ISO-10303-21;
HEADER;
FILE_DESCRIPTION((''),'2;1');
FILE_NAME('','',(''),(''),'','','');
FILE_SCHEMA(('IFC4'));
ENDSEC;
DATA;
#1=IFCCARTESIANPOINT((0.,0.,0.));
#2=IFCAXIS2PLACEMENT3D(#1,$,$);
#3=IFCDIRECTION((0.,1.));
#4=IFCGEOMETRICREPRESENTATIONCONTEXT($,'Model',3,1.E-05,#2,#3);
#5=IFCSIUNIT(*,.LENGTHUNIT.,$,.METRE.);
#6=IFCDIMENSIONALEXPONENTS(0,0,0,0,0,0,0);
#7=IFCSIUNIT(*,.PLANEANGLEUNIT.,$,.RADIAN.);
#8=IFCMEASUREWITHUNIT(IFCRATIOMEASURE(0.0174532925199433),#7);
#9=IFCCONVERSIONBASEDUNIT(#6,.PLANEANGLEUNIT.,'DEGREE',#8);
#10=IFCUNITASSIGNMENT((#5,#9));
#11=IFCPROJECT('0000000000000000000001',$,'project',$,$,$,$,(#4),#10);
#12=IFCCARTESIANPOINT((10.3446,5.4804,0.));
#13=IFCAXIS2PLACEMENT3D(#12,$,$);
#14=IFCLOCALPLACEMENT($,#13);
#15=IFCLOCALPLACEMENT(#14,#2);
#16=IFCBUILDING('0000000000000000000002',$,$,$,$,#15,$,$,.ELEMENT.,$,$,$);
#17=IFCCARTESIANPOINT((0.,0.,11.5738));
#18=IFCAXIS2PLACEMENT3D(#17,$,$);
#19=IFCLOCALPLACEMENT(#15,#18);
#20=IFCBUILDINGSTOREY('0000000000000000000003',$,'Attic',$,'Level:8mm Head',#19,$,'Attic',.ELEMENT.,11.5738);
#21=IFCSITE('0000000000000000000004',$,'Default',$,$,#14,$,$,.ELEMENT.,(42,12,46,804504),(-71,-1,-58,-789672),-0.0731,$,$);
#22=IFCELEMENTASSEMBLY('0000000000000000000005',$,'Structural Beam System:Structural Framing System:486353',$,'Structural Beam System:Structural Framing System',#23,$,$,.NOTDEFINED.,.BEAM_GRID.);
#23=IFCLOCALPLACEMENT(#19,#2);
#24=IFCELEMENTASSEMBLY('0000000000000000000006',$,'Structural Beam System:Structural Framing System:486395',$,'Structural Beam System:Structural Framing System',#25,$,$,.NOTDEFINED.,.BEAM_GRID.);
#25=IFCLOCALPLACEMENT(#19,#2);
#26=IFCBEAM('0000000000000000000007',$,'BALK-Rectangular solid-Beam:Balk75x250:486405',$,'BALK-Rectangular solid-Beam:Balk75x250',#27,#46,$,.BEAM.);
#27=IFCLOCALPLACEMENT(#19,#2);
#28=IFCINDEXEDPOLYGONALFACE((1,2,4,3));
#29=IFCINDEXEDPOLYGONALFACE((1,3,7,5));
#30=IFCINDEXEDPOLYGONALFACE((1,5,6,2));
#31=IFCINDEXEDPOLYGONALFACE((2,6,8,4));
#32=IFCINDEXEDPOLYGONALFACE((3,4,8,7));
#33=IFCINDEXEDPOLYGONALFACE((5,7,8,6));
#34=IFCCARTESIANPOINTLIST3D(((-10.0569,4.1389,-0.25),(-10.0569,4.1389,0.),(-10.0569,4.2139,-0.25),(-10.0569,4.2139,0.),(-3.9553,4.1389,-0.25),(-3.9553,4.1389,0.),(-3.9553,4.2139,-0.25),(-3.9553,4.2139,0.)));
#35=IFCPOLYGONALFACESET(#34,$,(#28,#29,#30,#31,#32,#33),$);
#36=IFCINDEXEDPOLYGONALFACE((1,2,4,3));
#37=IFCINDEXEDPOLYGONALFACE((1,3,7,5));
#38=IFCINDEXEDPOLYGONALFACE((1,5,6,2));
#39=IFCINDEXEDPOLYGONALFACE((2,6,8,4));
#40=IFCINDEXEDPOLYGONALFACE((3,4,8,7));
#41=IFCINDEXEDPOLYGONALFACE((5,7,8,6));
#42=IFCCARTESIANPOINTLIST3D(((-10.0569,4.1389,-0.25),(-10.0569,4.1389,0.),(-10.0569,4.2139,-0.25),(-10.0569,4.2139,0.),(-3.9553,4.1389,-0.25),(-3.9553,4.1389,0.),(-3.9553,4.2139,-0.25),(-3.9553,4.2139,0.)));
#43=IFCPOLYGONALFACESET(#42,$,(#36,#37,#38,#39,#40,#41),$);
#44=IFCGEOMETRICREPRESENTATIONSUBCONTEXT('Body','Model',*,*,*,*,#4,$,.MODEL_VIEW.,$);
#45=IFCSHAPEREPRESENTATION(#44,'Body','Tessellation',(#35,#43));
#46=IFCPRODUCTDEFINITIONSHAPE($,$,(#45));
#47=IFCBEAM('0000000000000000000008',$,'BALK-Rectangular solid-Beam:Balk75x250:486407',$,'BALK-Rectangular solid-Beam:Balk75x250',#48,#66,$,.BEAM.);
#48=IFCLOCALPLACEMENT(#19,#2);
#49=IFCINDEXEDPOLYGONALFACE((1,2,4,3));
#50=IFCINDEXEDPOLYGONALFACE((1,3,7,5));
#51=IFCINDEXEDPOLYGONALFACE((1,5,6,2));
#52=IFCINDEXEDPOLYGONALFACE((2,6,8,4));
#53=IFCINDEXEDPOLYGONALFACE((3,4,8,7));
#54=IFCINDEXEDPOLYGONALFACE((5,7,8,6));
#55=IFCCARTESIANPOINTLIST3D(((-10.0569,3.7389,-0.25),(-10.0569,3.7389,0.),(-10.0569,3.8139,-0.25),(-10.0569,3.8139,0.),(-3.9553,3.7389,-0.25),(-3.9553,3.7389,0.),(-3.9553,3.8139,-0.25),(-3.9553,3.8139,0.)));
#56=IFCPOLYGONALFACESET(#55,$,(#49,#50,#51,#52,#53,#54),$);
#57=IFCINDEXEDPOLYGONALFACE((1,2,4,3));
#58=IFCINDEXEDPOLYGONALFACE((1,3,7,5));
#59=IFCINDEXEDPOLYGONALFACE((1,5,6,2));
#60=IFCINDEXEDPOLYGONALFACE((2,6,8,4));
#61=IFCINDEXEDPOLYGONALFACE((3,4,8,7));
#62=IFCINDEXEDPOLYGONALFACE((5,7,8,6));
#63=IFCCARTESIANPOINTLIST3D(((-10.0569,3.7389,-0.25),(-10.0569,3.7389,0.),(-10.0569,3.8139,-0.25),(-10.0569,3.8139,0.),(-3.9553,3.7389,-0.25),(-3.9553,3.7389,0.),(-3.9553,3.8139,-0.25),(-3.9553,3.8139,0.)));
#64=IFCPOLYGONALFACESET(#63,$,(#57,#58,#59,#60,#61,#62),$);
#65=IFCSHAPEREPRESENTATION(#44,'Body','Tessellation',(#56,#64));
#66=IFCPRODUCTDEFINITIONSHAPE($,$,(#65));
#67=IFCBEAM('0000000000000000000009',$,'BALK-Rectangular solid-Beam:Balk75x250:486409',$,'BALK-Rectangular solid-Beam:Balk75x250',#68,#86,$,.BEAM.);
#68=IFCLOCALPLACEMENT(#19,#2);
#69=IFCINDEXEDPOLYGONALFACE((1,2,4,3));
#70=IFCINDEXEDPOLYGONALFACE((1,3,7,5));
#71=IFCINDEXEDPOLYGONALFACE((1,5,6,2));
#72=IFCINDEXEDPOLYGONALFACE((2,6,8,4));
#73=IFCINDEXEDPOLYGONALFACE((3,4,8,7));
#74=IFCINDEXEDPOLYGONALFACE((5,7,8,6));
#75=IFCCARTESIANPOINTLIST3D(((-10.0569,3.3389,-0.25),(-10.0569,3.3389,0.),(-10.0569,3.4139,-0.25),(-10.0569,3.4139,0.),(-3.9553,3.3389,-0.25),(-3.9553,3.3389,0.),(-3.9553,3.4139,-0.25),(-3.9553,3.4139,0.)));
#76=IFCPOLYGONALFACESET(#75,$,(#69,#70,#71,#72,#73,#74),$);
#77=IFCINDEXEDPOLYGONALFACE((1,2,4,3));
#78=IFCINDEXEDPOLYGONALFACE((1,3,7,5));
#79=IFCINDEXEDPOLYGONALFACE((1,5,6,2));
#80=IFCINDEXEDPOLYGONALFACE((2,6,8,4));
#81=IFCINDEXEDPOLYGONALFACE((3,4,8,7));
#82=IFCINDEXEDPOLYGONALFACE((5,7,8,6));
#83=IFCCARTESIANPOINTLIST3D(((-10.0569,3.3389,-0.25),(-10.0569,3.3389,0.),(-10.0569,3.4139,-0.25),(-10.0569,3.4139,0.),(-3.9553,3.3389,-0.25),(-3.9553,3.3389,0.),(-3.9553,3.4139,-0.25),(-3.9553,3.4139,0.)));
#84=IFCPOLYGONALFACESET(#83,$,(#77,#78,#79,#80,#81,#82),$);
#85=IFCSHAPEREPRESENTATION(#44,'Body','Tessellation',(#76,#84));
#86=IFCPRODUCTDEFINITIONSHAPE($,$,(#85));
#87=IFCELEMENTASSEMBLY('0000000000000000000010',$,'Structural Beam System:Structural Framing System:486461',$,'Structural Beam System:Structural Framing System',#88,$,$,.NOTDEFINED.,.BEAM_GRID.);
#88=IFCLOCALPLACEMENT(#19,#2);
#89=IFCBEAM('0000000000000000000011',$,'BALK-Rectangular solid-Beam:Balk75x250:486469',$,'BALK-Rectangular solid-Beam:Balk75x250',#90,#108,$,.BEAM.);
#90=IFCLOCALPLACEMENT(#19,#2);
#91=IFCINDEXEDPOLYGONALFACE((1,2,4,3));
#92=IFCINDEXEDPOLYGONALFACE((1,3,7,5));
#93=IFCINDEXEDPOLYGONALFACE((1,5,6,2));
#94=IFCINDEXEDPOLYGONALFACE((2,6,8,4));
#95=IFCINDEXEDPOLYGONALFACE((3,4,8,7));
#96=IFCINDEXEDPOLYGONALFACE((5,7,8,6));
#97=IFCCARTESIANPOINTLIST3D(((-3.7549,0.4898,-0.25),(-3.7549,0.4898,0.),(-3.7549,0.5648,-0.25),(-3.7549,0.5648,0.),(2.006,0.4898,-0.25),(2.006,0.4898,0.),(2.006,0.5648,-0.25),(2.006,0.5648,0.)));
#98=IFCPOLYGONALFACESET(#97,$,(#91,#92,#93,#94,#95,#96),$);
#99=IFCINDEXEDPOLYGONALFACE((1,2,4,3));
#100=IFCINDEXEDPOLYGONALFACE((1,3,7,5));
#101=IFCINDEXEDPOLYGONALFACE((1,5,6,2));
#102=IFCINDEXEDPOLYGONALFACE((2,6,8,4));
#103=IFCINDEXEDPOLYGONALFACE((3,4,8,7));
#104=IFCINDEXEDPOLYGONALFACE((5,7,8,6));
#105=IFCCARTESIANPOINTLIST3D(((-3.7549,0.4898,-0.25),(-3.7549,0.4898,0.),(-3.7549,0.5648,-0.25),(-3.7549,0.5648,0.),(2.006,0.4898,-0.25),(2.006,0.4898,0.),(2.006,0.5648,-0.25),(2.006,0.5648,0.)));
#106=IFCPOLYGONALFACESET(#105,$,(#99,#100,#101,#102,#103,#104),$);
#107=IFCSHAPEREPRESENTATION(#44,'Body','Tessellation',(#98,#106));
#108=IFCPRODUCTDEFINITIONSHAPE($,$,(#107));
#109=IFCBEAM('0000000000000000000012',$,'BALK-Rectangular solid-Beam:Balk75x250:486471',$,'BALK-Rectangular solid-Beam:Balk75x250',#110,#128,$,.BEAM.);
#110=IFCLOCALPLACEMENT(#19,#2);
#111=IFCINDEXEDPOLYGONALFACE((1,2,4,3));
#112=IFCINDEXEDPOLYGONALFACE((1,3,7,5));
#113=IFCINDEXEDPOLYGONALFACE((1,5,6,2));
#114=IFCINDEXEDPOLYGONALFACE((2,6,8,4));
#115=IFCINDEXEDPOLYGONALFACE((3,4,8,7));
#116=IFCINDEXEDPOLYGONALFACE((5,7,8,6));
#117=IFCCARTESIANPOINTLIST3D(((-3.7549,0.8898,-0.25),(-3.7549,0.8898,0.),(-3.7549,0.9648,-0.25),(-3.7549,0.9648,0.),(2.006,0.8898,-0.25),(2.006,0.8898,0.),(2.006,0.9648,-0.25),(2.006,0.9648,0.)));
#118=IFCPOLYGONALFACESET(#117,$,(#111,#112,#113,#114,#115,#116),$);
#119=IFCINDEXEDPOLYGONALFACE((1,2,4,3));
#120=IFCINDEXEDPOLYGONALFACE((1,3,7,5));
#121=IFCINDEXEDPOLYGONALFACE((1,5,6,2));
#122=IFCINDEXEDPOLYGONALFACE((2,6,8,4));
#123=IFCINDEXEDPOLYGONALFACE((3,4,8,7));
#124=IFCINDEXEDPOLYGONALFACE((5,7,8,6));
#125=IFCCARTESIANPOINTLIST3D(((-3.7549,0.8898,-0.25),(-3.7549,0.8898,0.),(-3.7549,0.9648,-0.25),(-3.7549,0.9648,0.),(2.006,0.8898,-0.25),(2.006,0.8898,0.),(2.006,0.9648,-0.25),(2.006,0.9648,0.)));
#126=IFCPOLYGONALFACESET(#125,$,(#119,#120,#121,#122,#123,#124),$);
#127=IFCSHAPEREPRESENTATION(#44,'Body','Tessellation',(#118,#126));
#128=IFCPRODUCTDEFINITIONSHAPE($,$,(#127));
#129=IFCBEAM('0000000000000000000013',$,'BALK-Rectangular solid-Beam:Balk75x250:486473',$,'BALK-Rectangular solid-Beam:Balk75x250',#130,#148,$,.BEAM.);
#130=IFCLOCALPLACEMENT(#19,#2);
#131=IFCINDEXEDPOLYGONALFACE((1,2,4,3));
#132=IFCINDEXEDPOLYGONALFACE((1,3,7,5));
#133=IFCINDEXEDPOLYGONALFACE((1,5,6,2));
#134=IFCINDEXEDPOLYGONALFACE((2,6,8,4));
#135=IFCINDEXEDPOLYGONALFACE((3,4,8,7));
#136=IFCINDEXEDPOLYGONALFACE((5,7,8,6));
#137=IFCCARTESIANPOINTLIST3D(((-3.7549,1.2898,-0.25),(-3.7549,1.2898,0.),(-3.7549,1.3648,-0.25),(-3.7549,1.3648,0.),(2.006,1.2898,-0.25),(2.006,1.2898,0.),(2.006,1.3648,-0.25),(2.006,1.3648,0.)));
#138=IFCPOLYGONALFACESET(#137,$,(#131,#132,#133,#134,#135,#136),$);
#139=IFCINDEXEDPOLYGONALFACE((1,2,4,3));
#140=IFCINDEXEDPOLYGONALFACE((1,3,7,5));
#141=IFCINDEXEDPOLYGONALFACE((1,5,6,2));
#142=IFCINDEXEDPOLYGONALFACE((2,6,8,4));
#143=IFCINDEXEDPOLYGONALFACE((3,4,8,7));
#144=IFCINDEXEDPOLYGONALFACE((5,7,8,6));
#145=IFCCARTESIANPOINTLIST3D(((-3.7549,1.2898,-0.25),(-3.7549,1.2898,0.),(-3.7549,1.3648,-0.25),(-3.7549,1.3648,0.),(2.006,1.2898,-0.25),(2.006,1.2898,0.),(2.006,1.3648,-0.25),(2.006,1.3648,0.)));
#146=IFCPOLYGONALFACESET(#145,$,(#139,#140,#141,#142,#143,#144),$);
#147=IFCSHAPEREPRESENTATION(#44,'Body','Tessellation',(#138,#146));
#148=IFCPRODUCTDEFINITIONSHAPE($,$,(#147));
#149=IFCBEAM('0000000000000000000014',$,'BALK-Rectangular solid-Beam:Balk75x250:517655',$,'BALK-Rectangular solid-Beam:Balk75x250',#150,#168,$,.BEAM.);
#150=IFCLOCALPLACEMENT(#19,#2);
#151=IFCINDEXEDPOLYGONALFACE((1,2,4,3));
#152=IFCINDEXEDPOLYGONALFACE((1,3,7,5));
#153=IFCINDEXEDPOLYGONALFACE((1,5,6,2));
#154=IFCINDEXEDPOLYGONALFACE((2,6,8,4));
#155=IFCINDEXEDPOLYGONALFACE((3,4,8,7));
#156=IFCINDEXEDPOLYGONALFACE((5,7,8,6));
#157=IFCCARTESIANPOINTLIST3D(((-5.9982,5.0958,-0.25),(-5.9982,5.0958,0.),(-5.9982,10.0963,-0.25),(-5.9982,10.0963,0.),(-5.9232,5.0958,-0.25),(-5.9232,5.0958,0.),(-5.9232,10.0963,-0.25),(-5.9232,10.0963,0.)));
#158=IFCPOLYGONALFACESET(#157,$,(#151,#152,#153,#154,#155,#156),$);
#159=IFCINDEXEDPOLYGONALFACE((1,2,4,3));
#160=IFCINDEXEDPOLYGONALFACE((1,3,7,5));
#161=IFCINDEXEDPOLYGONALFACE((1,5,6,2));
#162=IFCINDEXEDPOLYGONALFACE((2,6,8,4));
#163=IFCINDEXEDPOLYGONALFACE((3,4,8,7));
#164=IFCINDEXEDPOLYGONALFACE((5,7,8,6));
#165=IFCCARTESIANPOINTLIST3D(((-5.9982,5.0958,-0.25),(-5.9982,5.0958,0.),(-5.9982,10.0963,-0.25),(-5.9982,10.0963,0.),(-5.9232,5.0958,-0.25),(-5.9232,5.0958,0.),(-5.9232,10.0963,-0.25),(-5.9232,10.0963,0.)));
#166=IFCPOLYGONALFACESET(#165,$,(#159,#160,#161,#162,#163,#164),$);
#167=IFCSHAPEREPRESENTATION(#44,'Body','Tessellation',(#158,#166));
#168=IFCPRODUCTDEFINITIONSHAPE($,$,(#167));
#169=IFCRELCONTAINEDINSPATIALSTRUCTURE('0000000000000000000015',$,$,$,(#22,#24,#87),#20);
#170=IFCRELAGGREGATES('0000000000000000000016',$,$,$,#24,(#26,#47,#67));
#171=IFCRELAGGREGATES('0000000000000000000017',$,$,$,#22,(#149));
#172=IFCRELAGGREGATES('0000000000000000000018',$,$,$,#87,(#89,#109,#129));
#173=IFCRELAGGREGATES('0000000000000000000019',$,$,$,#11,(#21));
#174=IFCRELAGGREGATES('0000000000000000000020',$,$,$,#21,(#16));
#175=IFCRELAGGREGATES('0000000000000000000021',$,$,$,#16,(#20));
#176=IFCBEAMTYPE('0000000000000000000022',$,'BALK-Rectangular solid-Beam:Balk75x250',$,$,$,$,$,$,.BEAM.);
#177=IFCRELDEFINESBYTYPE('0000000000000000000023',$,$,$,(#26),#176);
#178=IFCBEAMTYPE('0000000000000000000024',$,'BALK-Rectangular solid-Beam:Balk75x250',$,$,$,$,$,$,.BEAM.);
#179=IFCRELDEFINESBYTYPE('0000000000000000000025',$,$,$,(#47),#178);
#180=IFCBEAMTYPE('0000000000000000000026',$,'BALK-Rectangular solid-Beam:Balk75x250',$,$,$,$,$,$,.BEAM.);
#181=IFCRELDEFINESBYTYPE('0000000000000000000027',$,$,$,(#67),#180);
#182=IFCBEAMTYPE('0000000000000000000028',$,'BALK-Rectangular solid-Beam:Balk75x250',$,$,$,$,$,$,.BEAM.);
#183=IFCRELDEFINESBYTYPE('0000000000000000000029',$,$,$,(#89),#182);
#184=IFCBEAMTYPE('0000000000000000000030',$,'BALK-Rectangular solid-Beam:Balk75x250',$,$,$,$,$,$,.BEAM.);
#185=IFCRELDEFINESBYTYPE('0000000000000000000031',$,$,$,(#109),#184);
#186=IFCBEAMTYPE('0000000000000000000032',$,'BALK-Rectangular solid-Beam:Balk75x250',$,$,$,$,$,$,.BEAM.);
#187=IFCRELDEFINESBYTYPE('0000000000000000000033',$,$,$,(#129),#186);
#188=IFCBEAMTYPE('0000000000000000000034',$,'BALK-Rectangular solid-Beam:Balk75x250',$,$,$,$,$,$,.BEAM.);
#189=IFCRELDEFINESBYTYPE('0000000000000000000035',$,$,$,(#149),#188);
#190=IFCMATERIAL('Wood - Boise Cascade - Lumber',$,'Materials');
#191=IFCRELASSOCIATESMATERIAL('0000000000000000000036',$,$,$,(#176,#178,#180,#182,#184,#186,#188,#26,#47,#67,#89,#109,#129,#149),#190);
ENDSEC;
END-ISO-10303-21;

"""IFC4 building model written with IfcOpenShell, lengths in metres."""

from ifc_helpers import new_model, entity, si_unit, converted_unit, direction, frame, frame_2d, origin, origin_2d_with_axis, place, context, subcontext, project, spatial, rectangle, extrude, source, transform, mapped, material, material_profile, profile_set, profile_usage, type_object, type_shapes, element, aggregate, save


model = new_model("IFC4")

# Units and contexts
model_context = context("Model", 3, precision=1e-05, world=origin(), true_north=direction((0.0, 1.0)))
body_context = subcontext(model_context, "Body", "Model", "MODEL_VIEW")
ifc_project = project(units=[si_unit("LENGTHUNIT", "METRE"), converted_unit("PLANEANGLEUNIT", "DEGREE", entity("IfcRatioMeasure", 0.0174532925199433), si_unit("PLANEANGLEUNIT", "RADIAN"), dimensions=[0, 0, 0, 0, 0, 0, 0])], contexts=[model_context])

# Site, building, storey
site_placement = place(None, frame((10.3446, 5.4804, 0.0)))
site = spatial("IfcSite", under=ifc_project, at=site_placement, Name="Default", CompositionType="ELEMENT", RefLatitude=(42, 12, 46, 804504), RefLongitude=(-71, -1, -58, -789672), RefElevation=-0.0731)
building_placement = place(site_placement, origin())
building = spatial("IfcBuilding", under=site, at=building_placement, CompositionType="ELEMENT")
storey_placement = place(building_placement, frame((0.0, 0.0, 11.5738)))
storey = spatial("IfcBuildingStorey", under=building, at=storey_placement, Name="Attic", ObjectType="Level:8mm Head", LongName="Attic", CompositionType="ELEMENT", Elevation=11.5738)

# Element assemblies, beams
assembly_1_placement = place(storey_placement, origin())
assembly_1 = element("IfcElementAssembly", 1, at=assembly_1_placement, inside=storey, Name="Structural Beam System:Structural Framing System:486353", ObjectType="Structural Beam System:Structural Framing System", AssemblyPlace="NOTDEFINED", PredefinedType="BEAM_GRID")
ifc_material = material(Name="Wood - Boise Cascade - Lumber", Category="Materials")
ifc_material_profile = material_profile(ifc_material, rectangle(XDim=0.25, YDim=0.075, at=frame_2d((0.0, 0.0), x_axis=(1.0, 0.0))), Name="Balk75x250")
ifc_profile_set = profile_set([ifc_material_profile], Name="Balk75x250")
assembly_2_placement = place(storey_placement, origin())
assembly_2 = element("IfcElementAssembly", 2, at=assembly_2_placement, inside=storey, Name="Structural Beam System:Structural Framing System:486395", ObjectType="Structural Beam System:Structural Framing System", AssemblyPlace="NOTDEFINED", PredefinedType="BEAM_GRID")
ifc_profile_usage_1 = profile_usage(ifc_profile_set, cardinal=8)
beam_type_1 = type_object("IfcBeamType", Name="BALK-Rectangular solid-Beam:Balk75x250", PredefinedType="BEAM", material=ifc_profile_set)
shared_shape_1 = source(origin(), body_context, "Body", "SweptSolid", [
    extrude(rectangle(XDim=0.25, YDim=0.075, at=frame_2d((0.0, 0.0), x_axis=(1.0, 0.0))), frame((-10.0569, 4.1764, 11.4488), z_axis=(1.0, 0.0, 0.0), x_axis=(0.0, 0.0, -1.0)), (0.0, 0.0, 1.0), 6.1016),
    extrude(rectangle(XDim=0.25, YDim=0.075, at=frame_2d((0.0, 0.0), x_axis=(1.0, 0.0))), frame((-10.0569, 4.1764, 11.4488), z_axis=(1.0, 0.0, 0.0), x_axis=(0.0, 0.0, -1.0)), (0.0, 0.0, 1.0), 6.1016),
])
type_shapes(beam_type_1, [shared_shape_1])
beam_1_placement = place(assembly_2_placement, frame((0.0, 0.0, -11.5738)))
beam_1 = element("IfcBeam", 3, at=beam_1_placement, type_object=beam_type_1, material=ifc_profile_usage_1, Name="BALK-Rectangular solid-Beam:Balk75x250:486405", ObjectType="BALK-Rectangular solid-Beam:Balk75x250", PredefinedType="BEAM", context=body_context, shape_type="MappedRepresentation", body=[
    mapped(shared_shape_1, transform((0.0, 0.0, 0.0), scale=1.0)),
])
ifc_profile_usage_2 = profile_usage(ifc_profile_set, cardinal=8)
beam_type_2 = type_object("IfcBeamType", Name="BALK-Rectangular solid-Beam:Balk75x250", PredefinedType="BEAM", material=ifc_profile_set)
shared_shape_2 = source(origin(), body_context, "Body", "SweptSolid", [
    extrude(rectangle(XDim=0.25, YDim=0.075, at=frame_2d((0.0, 0.0), x_axis=(1.0, 0.0))), frame((-10.0569, 3.7764, 11.4488), z_axis=(1.0, 0.0, 0.0), x_axis=(0.0, 0.0, -1.0)), (0.0, 0.0, 1.0), 6.1016),
    extrude(rectangle(XDim=0.25, YDim=0.075, at=frame_2d((0.0, 0.0), x_axis=(1.0, 0.0))), frame((-10.0569, 3.7764, 11.4488), z_axis=(1.0, 0.0, 0.0), x_axis=(0.0, 0.0, -1.0)), (0.0, 0.0, 1.0), 6.1016),
])
type_shapes(beam_type_2, [shared_shape_2])
beam_2_placement = place(assembly_2_placement, frame((0.0, 0.0, -11.5738)))
beam_2 = element("IfcBeam", 4, at=beam_2_placement, type_object=beam_type_2, material=ifc_profile_usage_2, Name="BALK-Rectangular solid-Beam:Balk75x250:486407", ObjectType="BALK-Rectangular solid-Beam:Balk75x250", PredefinedType="BEAM", context=body_context, shape_type="MappedRepresentation", body=[
    mapped(shared_shape_2, transform((0.0, 0.0, 0.0), scale=1.0)),
])
ifc_profile_usage_3 = profile_usage(ifc_profile_set, cardinal=8)
beam_type_3 = type_object("IfcBeamType", Name="BALK-Rectangular solid-Beam:Balk75x250", PredefinedType="BEAM", material=ifc_profile_set)
shared_shape_3 = source(origin(), body_context, "Body", "SweptSolid", [
    extrude(rectangle(XDim=0.25, YDim=0.075, at=frame_2d((0.0, 0.0), x_axis=(1.0, 0.0))), frame((-10.0569, 3.3764, 11.4488), z_axis=(1.0, 0.0, 0.0), x_axis=(0.0, 0.0, -1.0)), (0.0, 0.0, 1.0), 6.1016),
    extrude(rectangle(XDim=0.25, YDim=0.075, at=frame_2d((0.0, 0.0), x_axis=(1.0, 0.0))), frame((-10.0569, 3.3764, 11.4488), z_axis=(1.0, 0.0, 0.0), x_axis=(0.0, 0.0, -1.0)), (0.0, 0.0, 1.0), 6.1016),
])
type_shapes(beam_type_3, [shared_shape_3])
beam_3_placement = place(assembly_2_placement, frame((0.0, 0.0, -11.5738)))
beam_3 = element("IfcBeam", 5, at=beam_3_placement, type_object=beam_type_3, material=ifc_profile_usage_3, Name="BALK-Rectangular solid-Beam:Balk75x250:486409", ObjectType="BALK-Rectangular solid-Beam:Balk75x250", PredefinedType="BEAM", context=body_context, shape_type="MappedRepresentation", body=[
    mapped(shared_shape_3, transform((0.0, 0.0, 0.0), scale=1.0)),
])
aggregate(assembly_2, [beam_1, beam_2, beam_3])
assembly_3_placement = place(storey_placement, origin())
assembly_3 = element("IfcElementAssembly", 6, at=assembly_3_placement, inside=storey, Name="Structural Beam System:Structural Framing System:486461", ObjectType="Structural Beam System:Structural Framing System", AssemblyPlace="NOTDEFINED", PredefinedType="BEAM_GRID")
ifc_profile_usage_4 = profile_usage(ifc_profile_set, cardinal=8)
beam_type_4 = type_object("IfcBeamType", Name="BALK-Rectangular solid-Beam:Balk75x250", PredefinedType="BEAM", material=ifc_profile_set)
shared_shape_4 = source(origin(), body_context, "Body", "SweptSolid", [
    extrude(rectangle(XDim=0.25, YDim=0.075, at=frame_2d((0.0, 0.0), x_axis=(1.0, 0.0))), frame((2.006, 0.5273, 11.4488), z_axis=(-1.0, 0.0, 0.0), x_axis=(0.0, 0.0, -1.0)), (0.0, 0.0, 1.0), 5.7609),
    extrude(rectangle(XDim=0.25, YDim=0.075, at=frame_2d((0.0, 0.0), x_axis=(1.0, 0.0))), frame((2.006, 0.5273, 11.4488), z_axis=(-1.0, 0.0, 0.0), x_axis=(0.0, 0.0, -1.0)), (0.0, 0.0, 1.0), 5.7609),
])
type_shapes(beam_type_4, [shared_shape_4])
beam_4_placement = place(assembly_3_placement, frame((0.0, 0.0, -11.5738)))
beam_4 = element("IfcBeam", 7, at=beam_4_placement, type_object=beam_type_4, material=ifc_profile_usage_4, Name="BALK-Rectangular solid-Beam:Balk75x250:486469", ObjectType="BALK-Rectangular solid-Beam:Balk75x250", PredefinedType="BEAM", context=body_context, shape_type="MappedRepresentation", body=[
    mapped(shared_shape_4, transform((0.0, 0.0, 0.0), scale=1.0)),
])
ifc_profile_usage_5 = profile_usage(ifc_profile_set, cardinal=8)
beam_type_5 = type_object("IfcBeamType", Name="BALK-Rectangular solid-Beam:Balk75x250", PredefinedType="BEAM", material=ifc_profile_set)
shared_shape_5 = source(origin(), body_context, "Body", "SweptSolid", [
    extrude(rectangle(XDim=0.25, YDim=0.075, at=frame_2d((0.0, 0.0), x_axis=(1.0, 0.0))), frame((2.006, 0.9273, 11.4488), z_axis=(-1.0, 0.0, 0.0), x_axis=(0.0, 0.0, -1.0)), (0.0, 0.0, 1.0), 5.7609),
    extrude(rectangle(XDim=0.25, YDim=0.075, at=frame_2d((0.0, 0.0), x_axis=(1.0, 0.0))), frame((2.006, 0.9273, 11.4488), z_axis=(-1.0, 0.0, 0.0), x_axis=(0.0, 0.0, -1.0)), (0.0, 0.0, 1.0), 5.7609),
])
type_shapes(beam_type_5, [shared_shape_5])
beam_5_placement = place(assembly_3_placement, frame((0.0, 0.0, -11.5738)))
beam_5 = element("IfcBeam", 8, at=beam_5_placement, type_object=beam_type_5, material=ifc_profile_usage_5, Name="BALK-Rectangular solid-Beam:Balk75x250:486471", ObjectType="BALK-Rectangular solid-Beam:Balk75x250", PredefinedType="BEAM", context=body_context, shape_type="MappedRepresentation", body=[
    mapped(shared_shape_5, transform((0.0, 0.0, 0.0), scale=1.0)),
])
ifc_profile_usage_6 = profile_usage(ifc_profile_set, cardinal=8)
beam_type_6 = type_object("IfcBeamType", Name="BALK-Rectangular solid-Beam:Balk75x250", PredefinedType="BEAM", material=ifc_profile_set)
shared_shape_6 = source(origin(), body_context, "Body", "SweptSolid", [
    extrude(rectangle(XDim=0.25, YDim=0.075, at=frame_2d((0.0, 0.0), x_axis=(1.0, 0.0))), frame((2.006, 1.3273, 11.4488), z_axis=(-1.0, 0.0, 0.0), x_axis=(0.0, 0.0, -1.0)), (0.0, 0.0, 1.0), 5.7609),
    extrude(rectangle(XDim=0.25, YDim=0.075, at=frame_2d((0.0, 0.0), x_axis=(1.0, 0.0))), frame((2.006, 1.3273, 11.4488), z_axis=(-1.0, 0.0, 0.0), x_axis=(0.0, 0.0, -1.0)), (0.0, 0.0, 1.0), 5.7609),
])
type_shapes(beam_type_6, [shared_shape_6])
beam_6_placement = place(assembly_3_placement, frame((0.0, 0.0, -11.5738)))
beam_6 = element("IfcBeam", 9, at=beam_6_placement, type_object=beam_type_6, material=ifc_profile_usage_6, Name="BALK-Rectangular solid-Beam:Balk75x250:486473", ObjectType="BALK-Rectangular solid-Beam:Balk75x250", PredefinedType="BEAM", context=body_context, shape_type="MappedRepresentation", body=[
    mapped(shared_shape_6, transform((0.0, 0.0, 0.0), scale=1.0)),
])

# Beam
ifc_profile_usage_7 = profile_usage(ifc_profile_set, cardinal=8)
beam_type_7 = type_object("IfcBeamType", Name="BALK-Rectangular solid-Beam:Balk75x250", PredefinedType="BEAM", material=ifc_profile_set)
shared_shape_7 = source(origin(), body_context, "Body", "SweptSolid", [
    extrude(rectangle(XDim=0.25, YDim=0.075, at=origin_2d_with_axis()), frame((-2.394, 0.0, 0.0), z_axis=(1.0, 0.0, 0.0), x_axis=(0.0, 0.0, -1.0)), (0.0, 0.0, 1.0), 5.0005),
    extrude(rectangle(XDim=0.25, YDim=0.075, at=origin_2d_with_axis()), frame((-2.394, 0.0, 0.0), z_axis=(1.0, 0.0, 0.0), x_axis=(0.0, 0.0, -1.0)), (0.0, 0.0, 1.0), 5.0005),
])
type_shapes(beam_type_7, [shared_shape_7])
beam_7_placement = place(assembly_1_placement, frame((-5.9607, 7.7023, -0.125), z_axis=(0.0, 0.0, 1.0), x_axis=(0.0, -1.0, 0.0)))
beam_7 = element("IfcBeam", 10, at=beam_7_placement, type_object=beam_type_7, material=ifc_profile_usage_7, Name="BALK-Rectangular solid-Beam:Balk75x250:517655", ObjectType="BALK-Rectangular solid-Beam:Balk75x250", PredefinedType="BEAM", context=body_context, shape_type="MappedRepresentation", body=[
    mapped(shared_shape_7, transform((0.0, 0.0, 0.0), scale=1.0)),
])
aggregate(assembly_1, [beam_7])
aggregate(assembly_3, [beam_4, beam_5, beam_6])

save(model, "model.ifc")
